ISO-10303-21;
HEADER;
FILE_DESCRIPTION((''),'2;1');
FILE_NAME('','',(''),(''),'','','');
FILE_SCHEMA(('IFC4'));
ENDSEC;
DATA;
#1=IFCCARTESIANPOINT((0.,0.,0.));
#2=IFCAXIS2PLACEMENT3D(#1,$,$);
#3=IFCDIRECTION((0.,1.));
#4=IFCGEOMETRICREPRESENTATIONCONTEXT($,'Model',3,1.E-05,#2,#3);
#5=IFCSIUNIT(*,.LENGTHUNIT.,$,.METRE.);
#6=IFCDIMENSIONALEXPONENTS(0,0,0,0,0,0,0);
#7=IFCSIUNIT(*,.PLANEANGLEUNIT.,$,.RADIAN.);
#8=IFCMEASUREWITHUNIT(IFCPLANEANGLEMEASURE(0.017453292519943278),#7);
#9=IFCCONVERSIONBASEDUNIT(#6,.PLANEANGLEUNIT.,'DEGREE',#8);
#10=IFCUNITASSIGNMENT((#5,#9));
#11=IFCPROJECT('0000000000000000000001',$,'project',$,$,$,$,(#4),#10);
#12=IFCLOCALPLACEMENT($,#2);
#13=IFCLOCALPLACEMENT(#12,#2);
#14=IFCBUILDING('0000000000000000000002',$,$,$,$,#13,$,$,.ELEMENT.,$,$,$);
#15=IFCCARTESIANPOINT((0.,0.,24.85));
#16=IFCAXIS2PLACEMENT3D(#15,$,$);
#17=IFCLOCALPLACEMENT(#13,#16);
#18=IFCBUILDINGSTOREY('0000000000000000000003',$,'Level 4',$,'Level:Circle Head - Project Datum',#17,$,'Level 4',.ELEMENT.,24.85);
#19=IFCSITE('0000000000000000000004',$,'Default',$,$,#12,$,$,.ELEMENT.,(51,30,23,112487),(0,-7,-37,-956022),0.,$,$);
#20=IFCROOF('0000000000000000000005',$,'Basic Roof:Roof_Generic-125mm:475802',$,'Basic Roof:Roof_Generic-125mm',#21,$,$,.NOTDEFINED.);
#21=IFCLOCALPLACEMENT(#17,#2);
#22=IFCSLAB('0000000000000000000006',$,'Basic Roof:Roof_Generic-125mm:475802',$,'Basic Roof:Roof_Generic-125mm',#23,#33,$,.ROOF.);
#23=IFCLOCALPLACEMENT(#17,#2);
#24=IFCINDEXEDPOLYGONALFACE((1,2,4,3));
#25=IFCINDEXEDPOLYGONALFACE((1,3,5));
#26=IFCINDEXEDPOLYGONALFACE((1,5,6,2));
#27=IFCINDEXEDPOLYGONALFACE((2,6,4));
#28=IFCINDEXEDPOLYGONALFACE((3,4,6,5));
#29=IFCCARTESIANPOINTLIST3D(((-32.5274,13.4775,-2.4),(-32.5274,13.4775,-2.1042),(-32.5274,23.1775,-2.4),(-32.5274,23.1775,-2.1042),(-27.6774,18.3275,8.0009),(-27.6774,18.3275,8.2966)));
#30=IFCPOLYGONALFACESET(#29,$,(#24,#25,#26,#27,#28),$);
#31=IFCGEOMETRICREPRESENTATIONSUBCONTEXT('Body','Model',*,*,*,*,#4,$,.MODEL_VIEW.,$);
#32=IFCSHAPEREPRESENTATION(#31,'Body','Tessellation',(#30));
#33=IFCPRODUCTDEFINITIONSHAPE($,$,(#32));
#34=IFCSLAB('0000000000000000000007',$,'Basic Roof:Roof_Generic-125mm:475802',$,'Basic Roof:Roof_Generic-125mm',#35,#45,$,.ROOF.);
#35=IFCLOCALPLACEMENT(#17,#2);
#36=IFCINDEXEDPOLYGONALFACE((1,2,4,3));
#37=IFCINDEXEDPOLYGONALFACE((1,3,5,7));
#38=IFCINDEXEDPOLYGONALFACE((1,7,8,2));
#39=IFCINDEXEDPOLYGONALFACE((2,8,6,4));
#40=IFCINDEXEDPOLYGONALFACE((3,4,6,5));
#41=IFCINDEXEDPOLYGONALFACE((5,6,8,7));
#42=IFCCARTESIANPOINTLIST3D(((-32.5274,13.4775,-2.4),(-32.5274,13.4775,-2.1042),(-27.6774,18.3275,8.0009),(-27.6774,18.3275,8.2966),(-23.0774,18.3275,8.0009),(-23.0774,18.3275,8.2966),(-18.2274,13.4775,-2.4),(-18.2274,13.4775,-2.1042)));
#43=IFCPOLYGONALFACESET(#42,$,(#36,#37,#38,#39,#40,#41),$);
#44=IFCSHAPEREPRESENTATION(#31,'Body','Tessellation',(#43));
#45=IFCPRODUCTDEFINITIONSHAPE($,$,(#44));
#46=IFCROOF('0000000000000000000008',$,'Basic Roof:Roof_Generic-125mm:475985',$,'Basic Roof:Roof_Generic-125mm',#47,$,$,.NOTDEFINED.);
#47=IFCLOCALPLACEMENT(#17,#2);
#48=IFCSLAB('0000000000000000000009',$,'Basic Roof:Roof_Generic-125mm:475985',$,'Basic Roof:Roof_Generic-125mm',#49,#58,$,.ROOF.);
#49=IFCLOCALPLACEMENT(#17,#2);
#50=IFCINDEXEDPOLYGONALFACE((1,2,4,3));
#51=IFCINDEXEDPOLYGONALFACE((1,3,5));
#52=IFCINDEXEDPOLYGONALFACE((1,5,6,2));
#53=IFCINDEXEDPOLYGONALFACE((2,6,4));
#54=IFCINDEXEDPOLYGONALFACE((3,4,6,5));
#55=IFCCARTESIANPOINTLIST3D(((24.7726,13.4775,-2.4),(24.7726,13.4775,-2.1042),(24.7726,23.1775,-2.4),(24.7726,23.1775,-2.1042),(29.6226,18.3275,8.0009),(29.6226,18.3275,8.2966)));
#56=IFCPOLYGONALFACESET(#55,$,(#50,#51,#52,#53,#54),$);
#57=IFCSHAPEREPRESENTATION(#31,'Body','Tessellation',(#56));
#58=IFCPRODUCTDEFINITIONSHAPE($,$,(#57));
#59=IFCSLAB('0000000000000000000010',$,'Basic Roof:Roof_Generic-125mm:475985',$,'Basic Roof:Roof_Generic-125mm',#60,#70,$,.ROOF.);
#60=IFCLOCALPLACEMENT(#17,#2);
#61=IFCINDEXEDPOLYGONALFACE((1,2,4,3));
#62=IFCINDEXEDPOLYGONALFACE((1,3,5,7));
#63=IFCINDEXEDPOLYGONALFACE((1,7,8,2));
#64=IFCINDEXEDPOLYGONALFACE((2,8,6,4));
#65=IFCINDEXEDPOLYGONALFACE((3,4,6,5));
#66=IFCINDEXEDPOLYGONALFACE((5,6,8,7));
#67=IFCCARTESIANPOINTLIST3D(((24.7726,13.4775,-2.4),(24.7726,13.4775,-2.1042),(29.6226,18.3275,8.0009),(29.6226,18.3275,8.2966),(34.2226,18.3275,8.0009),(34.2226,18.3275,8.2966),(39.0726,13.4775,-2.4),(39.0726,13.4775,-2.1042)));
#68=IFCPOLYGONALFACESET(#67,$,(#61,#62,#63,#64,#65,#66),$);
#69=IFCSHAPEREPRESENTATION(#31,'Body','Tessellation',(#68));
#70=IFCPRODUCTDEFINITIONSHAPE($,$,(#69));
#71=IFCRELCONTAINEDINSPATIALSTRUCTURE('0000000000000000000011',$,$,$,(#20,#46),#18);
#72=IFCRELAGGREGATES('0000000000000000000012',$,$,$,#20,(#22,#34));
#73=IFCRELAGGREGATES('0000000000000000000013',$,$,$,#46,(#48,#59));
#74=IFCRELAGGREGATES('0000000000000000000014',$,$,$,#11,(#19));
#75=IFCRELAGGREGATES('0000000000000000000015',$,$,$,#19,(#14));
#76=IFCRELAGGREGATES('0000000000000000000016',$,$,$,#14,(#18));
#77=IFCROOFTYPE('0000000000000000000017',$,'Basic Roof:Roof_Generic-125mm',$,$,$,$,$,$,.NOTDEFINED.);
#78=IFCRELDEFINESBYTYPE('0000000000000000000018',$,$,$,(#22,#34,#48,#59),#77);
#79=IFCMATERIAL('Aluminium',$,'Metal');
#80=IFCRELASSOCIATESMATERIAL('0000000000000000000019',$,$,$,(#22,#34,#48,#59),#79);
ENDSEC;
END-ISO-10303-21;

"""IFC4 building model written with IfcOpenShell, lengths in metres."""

from ifc_helpers import new_model, entity, si_unit, converted_unit, direction, frame, origin, place, context, subcontext, project, spatial, indexed_curve, outline, extrude, material, type_object, element, aggregate, save


model = new_model("IFC4")

# Units and contexts
model_context = context("Model", 3, precision=1e-05, world=origin(), true_north=direction((0.0, 1.0)))
body_context = subcontext(model_context, "Body", "Model", "MODEL_VIEW")
ifc_project = project(units=[si_unit("LENGTHUNIT", "METRE"), converted_unit("PLANEANGLEUNIT", "DEGREE", entity("IfcPlaneAngleMeasure", 0.017453292519943278), si_unit("PLANEANGLEUNIT", "RADIAN"), dimensions=[0, 0, 0, 0, 0, 0, 0])], contexts=[model_context])

# Site, building, storey
site_placement = place(None, origin())
site = spatial("IfcSite", under=ifc_project, at=site_placement, Name="Default", CompositionType="ELEMENT", RefLatitude=(51, 30, 23, 112487), RefLongitude=(0, -7, -37, -956022), RefElevation=0.0)
building_placement = place(site_placement, origin())
building = spatial("IfcBuilding", under=site, at=building_placement, CompositionType="ELEMENT")
storey_placement = place(building_placement, frame((0.0, 0.0, 24.85)))
storey = spatial("IfcBuildingStorey", under=building, at=storey_placement, Name="Level 4", ObjectType="Level:Circle Head - Project Datum", LongName="Level 4", CompositionType="ELEMENT", Elevation=24.85)

# Roofs, slabs
roof_1_placement = place(storey_placement, frame((-32.5274, 13.4775, -2.4)))
roof_1 = element("IfcRoof", 1, at=roof_1_placement, inside=storey, Name="Basic Roof:Roof_Generic-125mm:475802", ObjectType="Basic Roof:Roof_Generic-125mm", PredefinedType="NOTDEFINED")
ifc_material = material(Name="Aluminium", Category="Metal")
roof_type = type_object("IfcRoofType", Name="Basic Roof:Roof_Generic-125mm", PredefinedType="NOTDEFINED")
slab_1_placement = place(roof_1_placement, origin())
slab_1 = element("IfcSlab", 2, at=slab_1_placement, type_object=roof_type, material=ifc_material, Name="Basic Roof:Roof_Generic-125mm:475802", ObjectType="Basic Roof:Roof_Generic-125mm", PredefinedType="ROOF", context=body_context, shape_type="SweptSolid", body=[
    extrude(outline(indexed_curve([(-5.738, 4.85), (-5.738, -4.85), (5.738, 0.0), (-5.738, 4.85)], self_intersect=False)), frame((2.425, 4.85, 5.2004), z_axis=(-0.906308, 0.0, 0.422618), x_axis=(0.422618, 0.0, 0.906308)), (0.906308, 0.0, 0.422618), 0.2958),
])
slab_2_placement = place(roof_1_placement, origin())
slab_2 = element("IfcSlab", 3, at=slab_2_placement, type_object=roof_type, material=ifc_material, Name="Basic Roof:Roof_Generic-125mm:475802", ObjectType="Basic Roof:Roof_Generic-125mm", PredefinedType="ROOF", context=body_context, shape_type="SweptSolid", body=[
    extrude(outline(indexed_curve([(-7.15, -5.738), (7.15, -5.738), (2.3, 5.738), (-2.3, 5.738), (-7.15, -5.738)], self_intersect=False)), frame((7.15, 2.425, 5.2004), z_axis=(0.0, -0.906308, 0.422618), x_axis=(1.0, 0.0, 0.0)), (0.0, 0.906308, 0.422618), 0.2958),
])
aggregate(roof_1, [slab_1, slab_2])
roof_2_placement = place(storey_placement, frame((24.7726, 13.4775, -2.4)))
roof_2 = element("IfcRoof", 4, at=roof_2_placement, inside=storey, Name="Basic Roof:Roof_Generic-125mm:475985", ObjectType="Basic Roof:Roof_Generic-125mm", PredefinedType="NOTDEFINED")
slab_3_placement = place(roof_2_placement, origin())
slab_3 = element("IfcSlab", 5, at=slab_3_placement, type_object=roof_type, material=ifc_material, Name="Basic Roof:Roof_Generic-125mm:475985", ObjectType="Basic Roof:Roof_Generic-125mm", PredefinedType="ROOF", context=body_context, shape_type="SweptSolid", body=[
    extrude(outline(indexed_curve([(-5.738, 4.85), (-5.738, -4.85), (5.738, 0.0), (-5.738, 4.85)], self_intersect=False)), frame((2.425, 4.85, 5.2004), z_axis=(-0.906308, 0.0, 0.422618), x_axis=(0.422618, 0.0, 0.906308)), (0.906308, 0.0, 0.422618), 0.2958),
])
slab_4_placement = place(roof_2_placement, origin())
slab_4 = element("IfcSlab", 6, at=slab_4_placement, type_object=roof_type, material=ifc_material, Name="Basic Roof:Roof_Generic-125mm:475985", ObjectType="Basic Roof:Roof_Generic-125mm", PredefinedType="ROOF", context=body_context, shape_type="SweptSolid", body=[
    extrude(outline(indexed_curve([(-7.15, -5.738), (7.15, -5.738), (2.3, 5.738), (-2.3, 5.738), (-7.15, -5.738)], self_intersect=False)), frame((7.15, 2.425, 5.2004), z_axis=(0.0, -0.906308, 0.422618), x_axis=(1.0, 0.0, 0.0)), (0.0, 0.906308, 0.422618), 0.2958),
])
aggregate(roof_2, [slab_3, slab_4])

save(model, "model.ifc")
